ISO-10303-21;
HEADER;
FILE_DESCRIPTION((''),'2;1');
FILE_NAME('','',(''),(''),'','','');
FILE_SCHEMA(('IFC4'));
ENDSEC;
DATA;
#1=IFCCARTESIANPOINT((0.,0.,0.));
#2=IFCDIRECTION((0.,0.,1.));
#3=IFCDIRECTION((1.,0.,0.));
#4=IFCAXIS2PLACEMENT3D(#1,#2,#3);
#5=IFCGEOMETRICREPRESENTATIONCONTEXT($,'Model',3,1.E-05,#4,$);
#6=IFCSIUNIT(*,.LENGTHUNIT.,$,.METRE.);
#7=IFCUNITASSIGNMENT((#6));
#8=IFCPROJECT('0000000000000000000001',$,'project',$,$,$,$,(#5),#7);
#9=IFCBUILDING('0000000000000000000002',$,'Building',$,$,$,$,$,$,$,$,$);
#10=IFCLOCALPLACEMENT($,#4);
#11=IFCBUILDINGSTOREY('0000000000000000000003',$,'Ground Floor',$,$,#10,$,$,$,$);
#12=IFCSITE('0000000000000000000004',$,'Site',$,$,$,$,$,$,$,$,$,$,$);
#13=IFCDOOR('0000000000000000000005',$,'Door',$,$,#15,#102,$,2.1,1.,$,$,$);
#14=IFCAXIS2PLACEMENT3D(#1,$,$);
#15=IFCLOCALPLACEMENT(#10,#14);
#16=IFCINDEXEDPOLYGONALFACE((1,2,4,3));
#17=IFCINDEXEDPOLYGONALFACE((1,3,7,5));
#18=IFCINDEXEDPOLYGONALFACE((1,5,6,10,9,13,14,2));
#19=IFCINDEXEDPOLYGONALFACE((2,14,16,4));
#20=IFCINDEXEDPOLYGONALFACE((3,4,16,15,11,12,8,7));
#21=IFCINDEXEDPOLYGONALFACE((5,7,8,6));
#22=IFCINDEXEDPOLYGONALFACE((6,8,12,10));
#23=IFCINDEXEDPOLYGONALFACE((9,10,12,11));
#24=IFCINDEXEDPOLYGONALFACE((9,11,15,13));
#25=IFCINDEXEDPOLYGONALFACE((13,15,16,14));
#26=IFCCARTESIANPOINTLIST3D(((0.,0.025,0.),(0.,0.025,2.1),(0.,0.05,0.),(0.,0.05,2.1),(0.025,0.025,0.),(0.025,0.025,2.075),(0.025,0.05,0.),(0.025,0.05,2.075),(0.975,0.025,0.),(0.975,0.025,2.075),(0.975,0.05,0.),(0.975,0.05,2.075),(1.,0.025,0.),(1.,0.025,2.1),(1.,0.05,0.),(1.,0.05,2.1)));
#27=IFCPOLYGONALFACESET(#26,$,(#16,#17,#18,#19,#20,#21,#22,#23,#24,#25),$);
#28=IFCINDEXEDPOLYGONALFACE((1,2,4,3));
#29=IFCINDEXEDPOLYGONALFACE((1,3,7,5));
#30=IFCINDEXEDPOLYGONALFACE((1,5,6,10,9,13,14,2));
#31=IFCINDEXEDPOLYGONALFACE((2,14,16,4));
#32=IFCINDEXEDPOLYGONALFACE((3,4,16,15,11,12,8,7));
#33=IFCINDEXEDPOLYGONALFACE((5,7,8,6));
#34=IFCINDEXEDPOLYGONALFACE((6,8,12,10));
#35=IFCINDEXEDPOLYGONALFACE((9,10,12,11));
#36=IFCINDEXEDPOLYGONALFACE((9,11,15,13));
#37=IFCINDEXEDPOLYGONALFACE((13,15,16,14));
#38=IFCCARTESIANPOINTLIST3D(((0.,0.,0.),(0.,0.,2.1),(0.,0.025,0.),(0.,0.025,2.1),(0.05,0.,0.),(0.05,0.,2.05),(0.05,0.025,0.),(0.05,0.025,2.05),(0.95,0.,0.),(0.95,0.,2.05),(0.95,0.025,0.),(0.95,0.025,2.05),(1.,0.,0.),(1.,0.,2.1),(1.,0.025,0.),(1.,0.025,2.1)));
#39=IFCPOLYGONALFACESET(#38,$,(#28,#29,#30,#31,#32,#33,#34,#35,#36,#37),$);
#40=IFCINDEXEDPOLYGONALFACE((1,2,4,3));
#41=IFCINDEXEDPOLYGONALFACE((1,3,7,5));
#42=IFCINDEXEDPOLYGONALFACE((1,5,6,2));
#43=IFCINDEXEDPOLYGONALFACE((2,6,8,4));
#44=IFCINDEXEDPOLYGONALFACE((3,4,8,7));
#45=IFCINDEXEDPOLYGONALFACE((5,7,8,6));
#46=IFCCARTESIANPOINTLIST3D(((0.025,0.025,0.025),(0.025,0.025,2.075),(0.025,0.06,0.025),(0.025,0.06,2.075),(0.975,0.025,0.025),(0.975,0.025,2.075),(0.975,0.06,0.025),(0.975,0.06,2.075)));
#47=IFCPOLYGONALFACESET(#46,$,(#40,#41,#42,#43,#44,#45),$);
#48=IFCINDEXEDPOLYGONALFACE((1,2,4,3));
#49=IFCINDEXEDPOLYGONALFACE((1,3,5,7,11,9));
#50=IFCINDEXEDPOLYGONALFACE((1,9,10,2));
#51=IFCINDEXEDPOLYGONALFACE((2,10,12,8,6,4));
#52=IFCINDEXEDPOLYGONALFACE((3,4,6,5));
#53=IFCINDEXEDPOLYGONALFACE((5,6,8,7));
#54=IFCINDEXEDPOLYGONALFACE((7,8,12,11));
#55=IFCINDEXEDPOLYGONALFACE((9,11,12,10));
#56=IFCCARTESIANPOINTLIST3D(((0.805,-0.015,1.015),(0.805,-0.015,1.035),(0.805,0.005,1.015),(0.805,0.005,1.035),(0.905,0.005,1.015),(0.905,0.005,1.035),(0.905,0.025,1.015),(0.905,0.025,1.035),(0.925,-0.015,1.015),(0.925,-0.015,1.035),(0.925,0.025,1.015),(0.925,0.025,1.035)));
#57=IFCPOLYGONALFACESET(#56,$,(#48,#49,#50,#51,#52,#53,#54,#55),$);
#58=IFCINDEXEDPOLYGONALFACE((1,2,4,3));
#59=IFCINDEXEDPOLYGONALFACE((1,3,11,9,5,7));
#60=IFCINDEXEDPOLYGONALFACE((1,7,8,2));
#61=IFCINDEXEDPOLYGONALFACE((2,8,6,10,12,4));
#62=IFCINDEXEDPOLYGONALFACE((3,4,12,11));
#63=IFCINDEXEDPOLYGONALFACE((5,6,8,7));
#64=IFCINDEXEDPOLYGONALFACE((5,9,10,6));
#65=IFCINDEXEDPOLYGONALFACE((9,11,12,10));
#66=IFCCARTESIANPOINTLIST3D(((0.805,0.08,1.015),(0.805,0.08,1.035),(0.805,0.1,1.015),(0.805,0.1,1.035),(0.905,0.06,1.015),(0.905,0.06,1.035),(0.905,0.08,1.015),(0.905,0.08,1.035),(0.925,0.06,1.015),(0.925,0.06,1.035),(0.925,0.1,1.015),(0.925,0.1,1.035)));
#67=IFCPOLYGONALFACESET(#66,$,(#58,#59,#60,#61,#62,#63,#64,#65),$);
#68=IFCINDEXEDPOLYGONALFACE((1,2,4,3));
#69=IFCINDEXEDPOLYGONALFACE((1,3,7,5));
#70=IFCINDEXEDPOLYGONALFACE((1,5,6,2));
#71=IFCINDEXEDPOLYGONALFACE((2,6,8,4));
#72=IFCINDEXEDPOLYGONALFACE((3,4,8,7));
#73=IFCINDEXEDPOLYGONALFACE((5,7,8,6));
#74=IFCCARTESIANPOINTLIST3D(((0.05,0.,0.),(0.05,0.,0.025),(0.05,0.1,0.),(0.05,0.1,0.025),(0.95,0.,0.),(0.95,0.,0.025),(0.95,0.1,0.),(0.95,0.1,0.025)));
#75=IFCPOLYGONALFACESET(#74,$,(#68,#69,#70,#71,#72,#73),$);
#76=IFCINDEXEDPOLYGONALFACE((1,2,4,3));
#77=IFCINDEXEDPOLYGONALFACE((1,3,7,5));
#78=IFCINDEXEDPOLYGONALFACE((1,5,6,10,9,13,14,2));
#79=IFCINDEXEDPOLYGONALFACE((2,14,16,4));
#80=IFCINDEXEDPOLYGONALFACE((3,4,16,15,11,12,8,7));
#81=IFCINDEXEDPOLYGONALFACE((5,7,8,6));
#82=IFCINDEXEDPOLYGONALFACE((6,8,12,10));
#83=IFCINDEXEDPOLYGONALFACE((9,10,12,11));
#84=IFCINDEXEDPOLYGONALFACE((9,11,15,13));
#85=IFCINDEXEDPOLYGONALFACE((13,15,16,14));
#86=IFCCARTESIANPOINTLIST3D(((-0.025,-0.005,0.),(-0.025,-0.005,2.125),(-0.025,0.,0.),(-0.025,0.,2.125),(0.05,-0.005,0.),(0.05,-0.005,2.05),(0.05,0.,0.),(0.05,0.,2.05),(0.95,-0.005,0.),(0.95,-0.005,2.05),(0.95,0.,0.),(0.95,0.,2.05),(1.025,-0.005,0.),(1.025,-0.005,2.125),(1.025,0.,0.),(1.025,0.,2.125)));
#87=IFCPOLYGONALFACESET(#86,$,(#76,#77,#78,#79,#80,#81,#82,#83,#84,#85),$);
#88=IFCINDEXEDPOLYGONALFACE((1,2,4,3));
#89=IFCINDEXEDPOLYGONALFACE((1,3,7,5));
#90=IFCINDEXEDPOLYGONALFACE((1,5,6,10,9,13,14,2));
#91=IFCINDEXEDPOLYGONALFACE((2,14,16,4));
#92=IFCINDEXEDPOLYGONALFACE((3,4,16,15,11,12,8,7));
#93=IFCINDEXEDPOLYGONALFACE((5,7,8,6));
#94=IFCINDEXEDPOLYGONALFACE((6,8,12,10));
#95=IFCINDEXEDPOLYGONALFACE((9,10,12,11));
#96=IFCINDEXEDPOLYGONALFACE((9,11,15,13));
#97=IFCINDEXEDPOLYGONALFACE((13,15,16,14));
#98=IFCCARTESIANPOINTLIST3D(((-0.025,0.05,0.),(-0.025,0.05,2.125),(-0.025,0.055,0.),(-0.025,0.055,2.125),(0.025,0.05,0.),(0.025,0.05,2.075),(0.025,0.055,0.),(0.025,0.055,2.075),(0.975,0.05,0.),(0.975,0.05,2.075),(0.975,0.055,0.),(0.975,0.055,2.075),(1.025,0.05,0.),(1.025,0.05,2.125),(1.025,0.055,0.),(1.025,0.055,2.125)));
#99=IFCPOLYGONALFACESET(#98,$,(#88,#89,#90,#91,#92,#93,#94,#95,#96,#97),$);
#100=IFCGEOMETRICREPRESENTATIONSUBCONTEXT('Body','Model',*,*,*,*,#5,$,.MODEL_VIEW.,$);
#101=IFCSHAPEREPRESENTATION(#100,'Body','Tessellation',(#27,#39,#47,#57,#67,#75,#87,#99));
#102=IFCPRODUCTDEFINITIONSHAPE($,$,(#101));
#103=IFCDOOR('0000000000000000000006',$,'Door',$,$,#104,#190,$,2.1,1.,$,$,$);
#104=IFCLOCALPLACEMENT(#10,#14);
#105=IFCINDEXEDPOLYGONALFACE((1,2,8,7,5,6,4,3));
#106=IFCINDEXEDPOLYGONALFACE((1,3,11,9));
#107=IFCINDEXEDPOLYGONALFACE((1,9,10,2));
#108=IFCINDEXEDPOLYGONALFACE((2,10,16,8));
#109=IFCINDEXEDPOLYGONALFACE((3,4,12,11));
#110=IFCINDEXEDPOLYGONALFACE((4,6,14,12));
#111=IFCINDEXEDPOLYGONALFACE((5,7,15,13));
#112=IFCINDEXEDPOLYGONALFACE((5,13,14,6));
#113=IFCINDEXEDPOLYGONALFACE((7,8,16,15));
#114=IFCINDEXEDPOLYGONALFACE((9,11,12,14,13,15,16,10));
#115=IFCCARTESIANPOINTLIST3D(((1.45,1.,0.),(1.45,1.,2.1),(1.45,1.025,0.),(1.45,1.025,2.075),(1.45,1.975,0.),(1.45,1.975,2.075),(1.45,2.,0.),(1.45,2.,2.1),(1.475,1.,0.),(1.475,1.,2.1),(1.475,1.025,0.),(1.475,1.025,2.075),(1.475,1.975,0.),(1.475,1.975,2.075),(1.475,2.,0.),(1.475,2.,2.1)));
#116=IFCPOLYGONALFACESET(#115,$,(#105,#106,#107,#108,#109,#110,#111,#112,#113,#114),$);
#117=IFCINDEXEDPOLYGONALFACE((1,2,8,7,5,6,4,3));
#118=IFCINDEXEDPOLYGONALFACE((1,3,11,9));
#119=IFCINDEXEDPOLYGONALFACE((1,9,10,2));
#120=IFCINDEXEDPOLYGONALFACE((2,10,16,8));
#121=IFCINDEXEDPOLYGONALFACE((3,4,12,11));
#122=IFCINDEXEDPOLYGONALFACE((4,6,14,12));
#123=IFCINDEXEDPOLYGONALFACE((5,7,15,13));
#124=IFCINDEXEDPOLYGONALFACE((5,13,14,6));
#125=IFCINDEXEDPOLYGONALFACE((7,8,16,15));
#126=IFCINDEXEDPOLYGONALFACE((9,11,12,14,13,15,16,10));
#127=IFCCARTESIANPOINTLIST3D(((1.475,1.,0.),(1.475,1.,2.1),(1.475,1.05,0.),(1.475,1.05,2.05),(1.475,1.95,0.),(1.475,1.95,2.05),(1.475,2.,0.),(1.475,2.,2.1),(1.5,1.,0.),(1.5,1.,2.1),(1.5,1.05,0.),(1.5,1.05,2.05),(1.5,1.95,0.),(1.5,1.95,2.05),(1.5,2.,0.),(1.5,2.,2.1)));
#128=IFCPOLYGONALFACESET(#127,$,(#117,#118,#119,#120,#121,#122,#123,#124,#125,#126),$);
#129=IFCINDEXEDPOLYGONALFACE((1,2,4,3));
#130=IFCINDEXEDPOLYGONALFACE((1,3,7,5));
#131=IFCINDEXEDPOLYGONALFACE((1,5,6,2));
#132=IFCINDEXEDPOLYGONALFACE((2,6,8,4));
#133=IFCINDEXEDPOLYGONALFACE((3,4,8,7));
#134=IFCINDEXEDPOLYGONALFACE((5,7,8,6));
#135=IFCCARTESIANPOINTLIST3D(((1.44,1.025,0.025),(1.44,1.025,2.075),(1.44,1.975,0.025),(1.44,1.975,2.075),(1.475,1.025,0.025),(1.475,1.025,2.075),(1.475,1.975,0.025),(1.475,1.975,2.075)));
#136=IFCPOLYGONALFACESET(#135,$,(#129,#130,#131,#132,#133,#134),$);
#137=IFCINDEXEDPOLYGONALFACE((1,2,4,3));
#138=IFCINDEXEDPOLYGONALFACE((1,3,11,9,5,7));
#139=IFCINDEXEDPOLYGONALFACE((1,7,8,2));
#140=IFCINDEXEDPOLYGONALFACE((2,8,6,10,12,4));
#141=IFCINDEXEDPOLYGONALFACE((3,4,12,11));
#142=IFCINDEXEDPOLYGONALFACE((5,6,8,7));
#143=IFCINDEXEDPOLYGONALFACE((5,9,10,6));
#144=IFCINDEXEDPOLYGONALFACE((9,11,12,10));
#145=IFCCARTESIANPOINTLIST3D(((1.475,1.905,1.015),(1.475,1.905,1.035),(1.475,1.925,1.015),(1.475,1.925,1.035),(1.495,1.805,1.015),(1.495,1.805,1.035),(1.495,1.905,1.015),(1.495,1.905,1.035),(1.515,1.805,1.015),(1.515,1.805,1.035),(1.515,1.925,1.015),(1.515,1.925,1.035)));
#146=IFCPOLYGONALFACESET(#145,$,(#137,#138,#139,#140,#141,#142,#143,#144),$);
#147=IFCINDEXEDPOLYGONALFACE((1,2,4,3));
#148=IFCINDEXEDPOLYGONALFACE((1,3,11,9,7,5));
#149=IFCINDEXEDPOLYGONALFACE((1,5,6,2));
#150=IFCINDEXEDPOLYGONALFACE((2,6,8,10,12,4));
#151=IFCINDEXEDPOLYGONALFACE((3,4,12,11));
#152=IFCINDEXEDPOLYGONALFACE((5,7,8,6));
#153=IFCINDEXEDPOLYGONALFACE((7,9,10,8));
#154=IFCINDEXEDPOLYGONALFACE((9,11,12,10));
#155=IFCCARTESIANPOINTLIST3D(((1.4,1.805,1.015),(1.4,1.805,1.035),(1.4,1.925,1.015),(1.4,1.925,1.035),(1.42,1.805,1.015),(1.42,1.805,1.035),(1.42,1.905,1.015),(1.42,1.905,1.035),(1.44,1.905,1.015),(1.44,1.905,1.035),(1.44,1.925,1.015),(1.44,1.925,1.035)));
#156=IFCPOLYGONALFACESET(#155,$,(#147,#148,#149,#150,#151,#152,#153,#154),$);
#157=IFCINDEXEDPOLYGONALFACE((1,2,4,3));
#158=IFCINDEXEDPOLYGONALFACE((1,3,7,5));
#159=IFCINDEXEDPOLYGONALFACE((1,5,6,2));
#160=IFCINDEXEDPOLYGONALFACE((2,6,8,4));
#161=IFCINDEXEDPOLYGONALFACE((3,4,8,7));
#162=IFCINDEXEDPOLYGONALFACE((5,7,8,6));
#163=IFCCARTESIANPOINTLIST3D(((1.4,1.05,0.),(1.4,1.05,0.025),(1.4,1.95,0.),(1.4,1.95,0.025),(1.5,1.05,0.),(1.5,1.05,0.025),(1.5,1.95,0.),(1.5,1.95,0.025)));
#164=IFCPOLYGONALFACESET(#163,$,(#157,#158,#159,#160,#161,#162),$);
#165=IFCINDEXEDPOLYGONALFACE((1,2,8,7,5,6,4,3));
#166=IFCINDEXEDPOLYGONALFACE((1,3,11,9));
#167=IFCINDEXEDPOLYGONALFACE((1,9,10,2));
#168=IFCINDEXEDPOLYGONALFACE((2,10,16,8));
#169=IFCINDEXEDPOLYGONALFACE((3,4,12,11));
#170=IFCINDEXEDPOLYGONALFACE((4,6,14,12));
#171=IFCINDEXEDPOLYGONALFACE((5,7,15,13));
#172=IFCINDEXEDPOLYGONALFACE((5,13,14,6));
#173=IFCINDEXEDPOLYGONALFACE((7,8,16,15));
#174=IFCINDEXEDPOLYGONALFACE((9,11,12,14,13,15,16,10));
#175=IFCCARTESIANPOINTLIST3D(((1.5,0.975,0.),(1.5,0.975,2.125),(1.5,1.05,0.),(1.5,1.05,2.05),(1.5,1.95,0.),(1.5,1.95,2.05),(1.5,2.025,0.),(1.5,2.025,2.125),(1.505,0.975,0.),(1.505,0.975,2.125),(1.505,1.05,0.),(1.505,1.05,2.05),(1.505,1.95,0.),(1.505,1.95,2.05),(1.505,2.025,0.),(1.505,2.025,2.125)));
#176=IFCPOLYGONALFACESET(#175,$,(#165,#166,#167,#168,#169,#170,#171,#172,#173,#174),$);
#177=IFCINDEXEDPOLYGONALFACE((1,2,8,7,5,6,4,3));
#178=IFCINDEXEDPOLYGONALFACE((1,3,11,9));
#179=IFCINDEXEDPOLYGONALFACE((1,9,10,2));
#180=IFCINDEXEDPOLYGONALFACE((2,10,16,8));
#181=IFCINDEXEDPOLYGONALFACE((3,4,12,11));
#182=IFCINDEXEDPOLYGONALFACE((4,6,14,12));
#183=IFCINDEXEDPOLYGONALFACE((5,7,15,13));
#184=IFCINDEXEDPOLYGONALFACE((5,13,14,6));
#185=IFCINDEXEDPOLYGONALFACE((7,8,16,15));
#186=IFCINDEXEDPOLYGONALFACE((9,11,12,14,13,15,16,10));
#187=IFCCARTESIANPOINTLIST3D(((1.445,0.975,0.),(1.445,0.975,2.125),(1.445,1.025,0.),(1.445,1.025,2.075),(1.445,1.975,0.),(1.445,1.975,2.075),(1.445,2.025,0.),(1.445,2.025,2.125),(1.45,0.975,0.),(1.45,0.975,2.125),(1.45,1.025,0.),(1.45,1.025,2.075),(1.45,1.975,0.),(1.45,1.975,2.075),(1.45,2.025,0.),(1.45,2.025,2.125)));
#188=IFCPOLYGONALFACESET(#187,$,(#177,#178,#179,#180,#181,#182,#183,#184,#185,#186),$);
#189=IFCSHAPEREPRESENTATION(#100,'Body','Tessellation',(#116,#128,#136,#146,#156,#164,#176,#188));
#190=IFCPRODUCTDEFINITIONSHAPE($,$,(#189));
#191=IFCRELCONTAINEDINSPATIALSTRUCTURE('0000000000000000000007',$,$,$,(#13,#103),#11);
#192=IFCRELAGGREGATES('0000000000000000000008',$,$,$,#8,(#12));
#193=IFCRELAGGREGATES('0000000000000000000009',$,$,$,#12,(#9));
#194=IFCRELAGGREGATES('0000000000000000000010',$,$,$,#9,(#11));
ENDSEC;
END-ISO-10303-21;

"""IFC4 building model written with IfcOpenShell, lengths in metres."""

from ifc_helpers import new_model, si_unit, frame, origin_with_axes, place, context, subcontext, project, spatial, line, indexed_curve, outline, extrude, element, save


model = new_model("IFC4")

# Units and contexts
model_context = context("Model", 3, precision=1e-05, world=origin_with_axes())
body_context = subcontext(model_context, "Body", "Model", "MODEL_VIEW")
ifc_project = project(units=[si_unit("LENGTHUNIT", "METRE")], contexts=[model_context])

# Site, building, storey
site = spatial("IfcSite", under=ifc_project, Name="Site")
building = spatial("IfcBuilding", under=site, Name="Building")
storey_placement = place(None, origin_with_axes())
storey = spatial("IfcBuildingStorey", under=building, at=storey_placement, Name="Ground Floor")

# Doors
door_1_placement = place(storey_placement, origin_with_axes())
element("IfcDoor", 1, at=door_1_placement, inside=storey, Name="Door", OverallHeight=2.1, OverallWidth=1.0, context=body_context, shape_type="SweptSolid", body=[
    extrude(outline(indexed_curve([(0.0, 0.0), (0.0, 2.1), (1.0, 2.1), (1.0, 0.0), (0.975, 0.0), (0.975, 2.075), (0.025, 2.075), (0.025, 0.0)], segments=[line(1, 2, 3, 4, 5, 6, 7, 8, 1)])), frame((0.0, 0.025, 0.0), z_axis=(0.0, -1.0, 0.0), x_axis=(1.0, 0.0, 0.0)), (0.0, 0.0, -1.0), 0.025),
    extrude(outline(indexed_curve([(0.0, 0.0), (0.0, 2.1), (1.0, 2.1), (1.0, 0.0), (0.95, 0.0), (0.95, 2.05), (0.05, 2.05), (0.05, 0.0)], segments=[line(1, 2, 3, 4, 5, 6, 7, 8, 1)])), frame((0.0, 0.0, 0.0), z_axis=(0.0, -1.0, 0.0), x_axis=(1.0, 0.0, 0.0)), (0.0, 0.0, -1.0), 0.025),
    extrude(outline(indexed_curve([(0.0, 0.0), (0.95, 0.0), (0.95, 0.035), (0.0, 0.035)], segments=[line(1, 2, 3, 4, 1)])), frame((0.025, 0.025, 0.025), z_axis=(0.0, 0.0, 1.0), x_axis=(1.0, 0.0, 0.0)), (0.0, 0.0, 1.0), 2.05),
    extrude(outline(indexed_curve([(0.0, 0.0), (0.0, -0.04), (-0.12, -0.04), (-0.12, -0.02), (-0.02, -0.02), (-0.02, 0.0)], segments=[line(1, 2, 3, 4, 5, 6, 1)])), frame((0.925, 0.025, 1.015), z_axis=(0.0, 0.0, 1.0), x_axis=(1.0, 0.0, 0.0)), (0.0, 0.0, 1.0), 0.02),
    extrude(outline(indexed_curve([(0.0, 0.0), (0.0, 0.04), (-0.12, 0.04), (-0.12, 0.02), (-0.02, 0.02), (-0.02, 0.0)], segments=[line(1, 2, 3, 4, 5, 6, 1)])), frame((0.925, 0.06, 1.015), z_axis=(0.0, 0.0, 1.0), x_axis=(1.0, 0.0, 0.0)), (0.0, 0.0, 1.0), 0.02),
    extrude(outline(indexed_curve([(0.0, 0.0), (0.9, 0.0), (0.9, 0.1), (0.0, 0.1)], segments=[line(1, 2, 3, 4, 1)])), frame((0.05, 0.0, 0.0), z_axis=(0.0, 0.0, 1.0), x_axis=(1.0, 0.0, 0.0)), (0.0, 0.0, 1.0), 0.025),
    extrude(outline(indexed_curve([(0.0, 0.0), (0.0, 2.125), (1.05, 2.125), (1.05, 0.0), (0.975, 0.0), (0.975, 2.05), (0.075, 2.05), (0.075, 0.0)], segments=[line(1, 2, 3, 4, 5, 6, 7, 8, 1)])), frame((-0.025, -0.005, 0.0), z_axis=(0.0, -1.0, 0.0), x_axis=(1.0, 0.0, 0.0)), (0.0, 0.0, -1.0), 0.005),
    extrude(outline(indexed_curve([(0.0, 0.0), (0.0, 2.125), (1.05, 2.125), (1.05, 0.0), (1.0, 0.0), (1.0, 2.075), (0.05, 2.075), (0.05, 0.0)], segments=[line(1, 2, 3, 4, 5, 6, 7, 8, 1)])), frame((-0.025, 0.05, 0.0), z_axis=(0.0, -1.0, 0.0), x_axis=(1.0, 0.0, 0.0)), (0.0, 0.0, -1.0), 0.005),
])
door_2_placement = place(storey_placement, frame((1.5, 1.0, 0.0), z_axis=(0.0, 0.0, 1.0), x_axis=(0.0, 1.0, 0.0)))
element("IfcDoor", 2, at=door_2_placement, inside=storey, Name="Door", OverallHeight=2.1, OverallWidth=1.0, context=body_context, shape_type="SweptSolid", body=[
    extrude(outline(indexed_curve([(0.0, 0.0), (0.0, 2.1), (1.0, 2.1), (1.0, 0.0), (0.975, 0.0), (0.975, 2.075), (0.025, 2.075), (0.025, 0.0)], segments=[line(1, 2, 3, 4, 5, 6, 7, 8, 1)])), frame((0.0, 0.025, 0.0), z_axis=(0.0, -1.0, 0.0), x_axis=(1.0, 0.0, 0.0)), (0.0, 0.0, -1.0), 0.025),
    extrude(outline(indexed_curve([(0.0, 0.0), (0.0, 2.1), (1.0, 2.1), (1.0, 0.0), (0.95, 0.0), (0.95, 2.05), (0.05, 2.05), (0.05, 0.0)], segments=[line(1, 2, 3, 4, 5, 6, 7, 8, 1)])), frame((0.0, 0.0, 0.0), z_axis=(0.0, -1.0, 0.0), x_axis=(1.0, 0.0, 0.0)), (0.0, 0.0, -1.0), 0.025),
    extrude(outline(indexed_curve([(0.0, 0.0), (0.95, 0.0), (0.95, 0.035), (0.0, 0.035)], segments=[line(1, 2, 3, 4, 1)])), frame((0.025, 0.025, 0.025), z_axis=(0.0, 0.0, 1.0), x_axis=(1.0, 0.0, 0.0)), (0.0, 0.0, 1.0), 2.05),
    extrude(outline(indexed_curve([(0.0, 0.0), (0.0, -0.04), (-0.12, -0.04), (-0.12, -0.02), (-0.02, -0.02), (-0.02, 0.0)], segments=[line(1, 2, 3, 4, 5, 6, 1)])), frame((0.925, 0.025, 1.015), z_axis=(0.0, 0.0, 1.0), x_axis=(1.0, 0.0, 0.0)), (0.0, 0.0, 1.0), 0.02),
    extrude(outline(indexed_curve([(0.0, 0.0), (0.0, 0.04), (-0.12, 0.04), (-0.12, 0.02), (-0.02, 0.02), (-0.02, 0.0)], segments=[line(1, 2, 3, 4, 5, 6, 1)])), frame((0.925, 0.06, 1.015), z_axis=(0.0, 0.0, 1.0), x_axis=(1.0, 0.0, 0.0)), (0.0, 0.0, 1.0), 0.02),
    extrude(outline(indexed_curve([(0.0, 0.0), (0.9, 0.0), (0.9, 0.1), (0.0, 0.1)], segments=[line(1, 2, 3, 4, 1)])), frame((0.05, 0.0, 0.0), z_axis=(0.0, 0.0, 1.0), x_axis=(1.0, 0.0, 0.0)), (0.0, 0.0, 1.0), 0.025),
    extrude(outline(indexed_curve([(0.0, 0.0), (0.0, 2.125), (1.05, 2.125), (1.05, 0.0), (0.975, 0.0), (0.975, 2.05), (0.075, 2.05), (0.075, 0.0)], segments=[line(1, 2, 3, 4, 5, 6, 7, 8, 1)])), frame((-0.025, -0.005, 0.0), z_axis=(0.0, -1.0, 0.0), x_axis=(1.0, 0.0, 0.0)), (0.0, 0.0, -1.0), 0.005),
    extrude(outline(indexed_curve([(0.0, 0.0), (0.0, 2.125), (1.05, 2.125), (1.05, 0.0), (1.0, 0.0), (1.0, 2.075), (0.05, 2.075), (0.05, 0.0)], segments=[line(1, 2, 3, 4, 5, 6, 7, 8, 1)])), frame((-0.025, 0.05, 0.0), z_axis=(0.0, -1.0, 0.0), x_axis=(1.0, 0.0, 0.0)), (0.0, 0.0, -1.0), 0.005),
])

save(model, "model.ifc")
